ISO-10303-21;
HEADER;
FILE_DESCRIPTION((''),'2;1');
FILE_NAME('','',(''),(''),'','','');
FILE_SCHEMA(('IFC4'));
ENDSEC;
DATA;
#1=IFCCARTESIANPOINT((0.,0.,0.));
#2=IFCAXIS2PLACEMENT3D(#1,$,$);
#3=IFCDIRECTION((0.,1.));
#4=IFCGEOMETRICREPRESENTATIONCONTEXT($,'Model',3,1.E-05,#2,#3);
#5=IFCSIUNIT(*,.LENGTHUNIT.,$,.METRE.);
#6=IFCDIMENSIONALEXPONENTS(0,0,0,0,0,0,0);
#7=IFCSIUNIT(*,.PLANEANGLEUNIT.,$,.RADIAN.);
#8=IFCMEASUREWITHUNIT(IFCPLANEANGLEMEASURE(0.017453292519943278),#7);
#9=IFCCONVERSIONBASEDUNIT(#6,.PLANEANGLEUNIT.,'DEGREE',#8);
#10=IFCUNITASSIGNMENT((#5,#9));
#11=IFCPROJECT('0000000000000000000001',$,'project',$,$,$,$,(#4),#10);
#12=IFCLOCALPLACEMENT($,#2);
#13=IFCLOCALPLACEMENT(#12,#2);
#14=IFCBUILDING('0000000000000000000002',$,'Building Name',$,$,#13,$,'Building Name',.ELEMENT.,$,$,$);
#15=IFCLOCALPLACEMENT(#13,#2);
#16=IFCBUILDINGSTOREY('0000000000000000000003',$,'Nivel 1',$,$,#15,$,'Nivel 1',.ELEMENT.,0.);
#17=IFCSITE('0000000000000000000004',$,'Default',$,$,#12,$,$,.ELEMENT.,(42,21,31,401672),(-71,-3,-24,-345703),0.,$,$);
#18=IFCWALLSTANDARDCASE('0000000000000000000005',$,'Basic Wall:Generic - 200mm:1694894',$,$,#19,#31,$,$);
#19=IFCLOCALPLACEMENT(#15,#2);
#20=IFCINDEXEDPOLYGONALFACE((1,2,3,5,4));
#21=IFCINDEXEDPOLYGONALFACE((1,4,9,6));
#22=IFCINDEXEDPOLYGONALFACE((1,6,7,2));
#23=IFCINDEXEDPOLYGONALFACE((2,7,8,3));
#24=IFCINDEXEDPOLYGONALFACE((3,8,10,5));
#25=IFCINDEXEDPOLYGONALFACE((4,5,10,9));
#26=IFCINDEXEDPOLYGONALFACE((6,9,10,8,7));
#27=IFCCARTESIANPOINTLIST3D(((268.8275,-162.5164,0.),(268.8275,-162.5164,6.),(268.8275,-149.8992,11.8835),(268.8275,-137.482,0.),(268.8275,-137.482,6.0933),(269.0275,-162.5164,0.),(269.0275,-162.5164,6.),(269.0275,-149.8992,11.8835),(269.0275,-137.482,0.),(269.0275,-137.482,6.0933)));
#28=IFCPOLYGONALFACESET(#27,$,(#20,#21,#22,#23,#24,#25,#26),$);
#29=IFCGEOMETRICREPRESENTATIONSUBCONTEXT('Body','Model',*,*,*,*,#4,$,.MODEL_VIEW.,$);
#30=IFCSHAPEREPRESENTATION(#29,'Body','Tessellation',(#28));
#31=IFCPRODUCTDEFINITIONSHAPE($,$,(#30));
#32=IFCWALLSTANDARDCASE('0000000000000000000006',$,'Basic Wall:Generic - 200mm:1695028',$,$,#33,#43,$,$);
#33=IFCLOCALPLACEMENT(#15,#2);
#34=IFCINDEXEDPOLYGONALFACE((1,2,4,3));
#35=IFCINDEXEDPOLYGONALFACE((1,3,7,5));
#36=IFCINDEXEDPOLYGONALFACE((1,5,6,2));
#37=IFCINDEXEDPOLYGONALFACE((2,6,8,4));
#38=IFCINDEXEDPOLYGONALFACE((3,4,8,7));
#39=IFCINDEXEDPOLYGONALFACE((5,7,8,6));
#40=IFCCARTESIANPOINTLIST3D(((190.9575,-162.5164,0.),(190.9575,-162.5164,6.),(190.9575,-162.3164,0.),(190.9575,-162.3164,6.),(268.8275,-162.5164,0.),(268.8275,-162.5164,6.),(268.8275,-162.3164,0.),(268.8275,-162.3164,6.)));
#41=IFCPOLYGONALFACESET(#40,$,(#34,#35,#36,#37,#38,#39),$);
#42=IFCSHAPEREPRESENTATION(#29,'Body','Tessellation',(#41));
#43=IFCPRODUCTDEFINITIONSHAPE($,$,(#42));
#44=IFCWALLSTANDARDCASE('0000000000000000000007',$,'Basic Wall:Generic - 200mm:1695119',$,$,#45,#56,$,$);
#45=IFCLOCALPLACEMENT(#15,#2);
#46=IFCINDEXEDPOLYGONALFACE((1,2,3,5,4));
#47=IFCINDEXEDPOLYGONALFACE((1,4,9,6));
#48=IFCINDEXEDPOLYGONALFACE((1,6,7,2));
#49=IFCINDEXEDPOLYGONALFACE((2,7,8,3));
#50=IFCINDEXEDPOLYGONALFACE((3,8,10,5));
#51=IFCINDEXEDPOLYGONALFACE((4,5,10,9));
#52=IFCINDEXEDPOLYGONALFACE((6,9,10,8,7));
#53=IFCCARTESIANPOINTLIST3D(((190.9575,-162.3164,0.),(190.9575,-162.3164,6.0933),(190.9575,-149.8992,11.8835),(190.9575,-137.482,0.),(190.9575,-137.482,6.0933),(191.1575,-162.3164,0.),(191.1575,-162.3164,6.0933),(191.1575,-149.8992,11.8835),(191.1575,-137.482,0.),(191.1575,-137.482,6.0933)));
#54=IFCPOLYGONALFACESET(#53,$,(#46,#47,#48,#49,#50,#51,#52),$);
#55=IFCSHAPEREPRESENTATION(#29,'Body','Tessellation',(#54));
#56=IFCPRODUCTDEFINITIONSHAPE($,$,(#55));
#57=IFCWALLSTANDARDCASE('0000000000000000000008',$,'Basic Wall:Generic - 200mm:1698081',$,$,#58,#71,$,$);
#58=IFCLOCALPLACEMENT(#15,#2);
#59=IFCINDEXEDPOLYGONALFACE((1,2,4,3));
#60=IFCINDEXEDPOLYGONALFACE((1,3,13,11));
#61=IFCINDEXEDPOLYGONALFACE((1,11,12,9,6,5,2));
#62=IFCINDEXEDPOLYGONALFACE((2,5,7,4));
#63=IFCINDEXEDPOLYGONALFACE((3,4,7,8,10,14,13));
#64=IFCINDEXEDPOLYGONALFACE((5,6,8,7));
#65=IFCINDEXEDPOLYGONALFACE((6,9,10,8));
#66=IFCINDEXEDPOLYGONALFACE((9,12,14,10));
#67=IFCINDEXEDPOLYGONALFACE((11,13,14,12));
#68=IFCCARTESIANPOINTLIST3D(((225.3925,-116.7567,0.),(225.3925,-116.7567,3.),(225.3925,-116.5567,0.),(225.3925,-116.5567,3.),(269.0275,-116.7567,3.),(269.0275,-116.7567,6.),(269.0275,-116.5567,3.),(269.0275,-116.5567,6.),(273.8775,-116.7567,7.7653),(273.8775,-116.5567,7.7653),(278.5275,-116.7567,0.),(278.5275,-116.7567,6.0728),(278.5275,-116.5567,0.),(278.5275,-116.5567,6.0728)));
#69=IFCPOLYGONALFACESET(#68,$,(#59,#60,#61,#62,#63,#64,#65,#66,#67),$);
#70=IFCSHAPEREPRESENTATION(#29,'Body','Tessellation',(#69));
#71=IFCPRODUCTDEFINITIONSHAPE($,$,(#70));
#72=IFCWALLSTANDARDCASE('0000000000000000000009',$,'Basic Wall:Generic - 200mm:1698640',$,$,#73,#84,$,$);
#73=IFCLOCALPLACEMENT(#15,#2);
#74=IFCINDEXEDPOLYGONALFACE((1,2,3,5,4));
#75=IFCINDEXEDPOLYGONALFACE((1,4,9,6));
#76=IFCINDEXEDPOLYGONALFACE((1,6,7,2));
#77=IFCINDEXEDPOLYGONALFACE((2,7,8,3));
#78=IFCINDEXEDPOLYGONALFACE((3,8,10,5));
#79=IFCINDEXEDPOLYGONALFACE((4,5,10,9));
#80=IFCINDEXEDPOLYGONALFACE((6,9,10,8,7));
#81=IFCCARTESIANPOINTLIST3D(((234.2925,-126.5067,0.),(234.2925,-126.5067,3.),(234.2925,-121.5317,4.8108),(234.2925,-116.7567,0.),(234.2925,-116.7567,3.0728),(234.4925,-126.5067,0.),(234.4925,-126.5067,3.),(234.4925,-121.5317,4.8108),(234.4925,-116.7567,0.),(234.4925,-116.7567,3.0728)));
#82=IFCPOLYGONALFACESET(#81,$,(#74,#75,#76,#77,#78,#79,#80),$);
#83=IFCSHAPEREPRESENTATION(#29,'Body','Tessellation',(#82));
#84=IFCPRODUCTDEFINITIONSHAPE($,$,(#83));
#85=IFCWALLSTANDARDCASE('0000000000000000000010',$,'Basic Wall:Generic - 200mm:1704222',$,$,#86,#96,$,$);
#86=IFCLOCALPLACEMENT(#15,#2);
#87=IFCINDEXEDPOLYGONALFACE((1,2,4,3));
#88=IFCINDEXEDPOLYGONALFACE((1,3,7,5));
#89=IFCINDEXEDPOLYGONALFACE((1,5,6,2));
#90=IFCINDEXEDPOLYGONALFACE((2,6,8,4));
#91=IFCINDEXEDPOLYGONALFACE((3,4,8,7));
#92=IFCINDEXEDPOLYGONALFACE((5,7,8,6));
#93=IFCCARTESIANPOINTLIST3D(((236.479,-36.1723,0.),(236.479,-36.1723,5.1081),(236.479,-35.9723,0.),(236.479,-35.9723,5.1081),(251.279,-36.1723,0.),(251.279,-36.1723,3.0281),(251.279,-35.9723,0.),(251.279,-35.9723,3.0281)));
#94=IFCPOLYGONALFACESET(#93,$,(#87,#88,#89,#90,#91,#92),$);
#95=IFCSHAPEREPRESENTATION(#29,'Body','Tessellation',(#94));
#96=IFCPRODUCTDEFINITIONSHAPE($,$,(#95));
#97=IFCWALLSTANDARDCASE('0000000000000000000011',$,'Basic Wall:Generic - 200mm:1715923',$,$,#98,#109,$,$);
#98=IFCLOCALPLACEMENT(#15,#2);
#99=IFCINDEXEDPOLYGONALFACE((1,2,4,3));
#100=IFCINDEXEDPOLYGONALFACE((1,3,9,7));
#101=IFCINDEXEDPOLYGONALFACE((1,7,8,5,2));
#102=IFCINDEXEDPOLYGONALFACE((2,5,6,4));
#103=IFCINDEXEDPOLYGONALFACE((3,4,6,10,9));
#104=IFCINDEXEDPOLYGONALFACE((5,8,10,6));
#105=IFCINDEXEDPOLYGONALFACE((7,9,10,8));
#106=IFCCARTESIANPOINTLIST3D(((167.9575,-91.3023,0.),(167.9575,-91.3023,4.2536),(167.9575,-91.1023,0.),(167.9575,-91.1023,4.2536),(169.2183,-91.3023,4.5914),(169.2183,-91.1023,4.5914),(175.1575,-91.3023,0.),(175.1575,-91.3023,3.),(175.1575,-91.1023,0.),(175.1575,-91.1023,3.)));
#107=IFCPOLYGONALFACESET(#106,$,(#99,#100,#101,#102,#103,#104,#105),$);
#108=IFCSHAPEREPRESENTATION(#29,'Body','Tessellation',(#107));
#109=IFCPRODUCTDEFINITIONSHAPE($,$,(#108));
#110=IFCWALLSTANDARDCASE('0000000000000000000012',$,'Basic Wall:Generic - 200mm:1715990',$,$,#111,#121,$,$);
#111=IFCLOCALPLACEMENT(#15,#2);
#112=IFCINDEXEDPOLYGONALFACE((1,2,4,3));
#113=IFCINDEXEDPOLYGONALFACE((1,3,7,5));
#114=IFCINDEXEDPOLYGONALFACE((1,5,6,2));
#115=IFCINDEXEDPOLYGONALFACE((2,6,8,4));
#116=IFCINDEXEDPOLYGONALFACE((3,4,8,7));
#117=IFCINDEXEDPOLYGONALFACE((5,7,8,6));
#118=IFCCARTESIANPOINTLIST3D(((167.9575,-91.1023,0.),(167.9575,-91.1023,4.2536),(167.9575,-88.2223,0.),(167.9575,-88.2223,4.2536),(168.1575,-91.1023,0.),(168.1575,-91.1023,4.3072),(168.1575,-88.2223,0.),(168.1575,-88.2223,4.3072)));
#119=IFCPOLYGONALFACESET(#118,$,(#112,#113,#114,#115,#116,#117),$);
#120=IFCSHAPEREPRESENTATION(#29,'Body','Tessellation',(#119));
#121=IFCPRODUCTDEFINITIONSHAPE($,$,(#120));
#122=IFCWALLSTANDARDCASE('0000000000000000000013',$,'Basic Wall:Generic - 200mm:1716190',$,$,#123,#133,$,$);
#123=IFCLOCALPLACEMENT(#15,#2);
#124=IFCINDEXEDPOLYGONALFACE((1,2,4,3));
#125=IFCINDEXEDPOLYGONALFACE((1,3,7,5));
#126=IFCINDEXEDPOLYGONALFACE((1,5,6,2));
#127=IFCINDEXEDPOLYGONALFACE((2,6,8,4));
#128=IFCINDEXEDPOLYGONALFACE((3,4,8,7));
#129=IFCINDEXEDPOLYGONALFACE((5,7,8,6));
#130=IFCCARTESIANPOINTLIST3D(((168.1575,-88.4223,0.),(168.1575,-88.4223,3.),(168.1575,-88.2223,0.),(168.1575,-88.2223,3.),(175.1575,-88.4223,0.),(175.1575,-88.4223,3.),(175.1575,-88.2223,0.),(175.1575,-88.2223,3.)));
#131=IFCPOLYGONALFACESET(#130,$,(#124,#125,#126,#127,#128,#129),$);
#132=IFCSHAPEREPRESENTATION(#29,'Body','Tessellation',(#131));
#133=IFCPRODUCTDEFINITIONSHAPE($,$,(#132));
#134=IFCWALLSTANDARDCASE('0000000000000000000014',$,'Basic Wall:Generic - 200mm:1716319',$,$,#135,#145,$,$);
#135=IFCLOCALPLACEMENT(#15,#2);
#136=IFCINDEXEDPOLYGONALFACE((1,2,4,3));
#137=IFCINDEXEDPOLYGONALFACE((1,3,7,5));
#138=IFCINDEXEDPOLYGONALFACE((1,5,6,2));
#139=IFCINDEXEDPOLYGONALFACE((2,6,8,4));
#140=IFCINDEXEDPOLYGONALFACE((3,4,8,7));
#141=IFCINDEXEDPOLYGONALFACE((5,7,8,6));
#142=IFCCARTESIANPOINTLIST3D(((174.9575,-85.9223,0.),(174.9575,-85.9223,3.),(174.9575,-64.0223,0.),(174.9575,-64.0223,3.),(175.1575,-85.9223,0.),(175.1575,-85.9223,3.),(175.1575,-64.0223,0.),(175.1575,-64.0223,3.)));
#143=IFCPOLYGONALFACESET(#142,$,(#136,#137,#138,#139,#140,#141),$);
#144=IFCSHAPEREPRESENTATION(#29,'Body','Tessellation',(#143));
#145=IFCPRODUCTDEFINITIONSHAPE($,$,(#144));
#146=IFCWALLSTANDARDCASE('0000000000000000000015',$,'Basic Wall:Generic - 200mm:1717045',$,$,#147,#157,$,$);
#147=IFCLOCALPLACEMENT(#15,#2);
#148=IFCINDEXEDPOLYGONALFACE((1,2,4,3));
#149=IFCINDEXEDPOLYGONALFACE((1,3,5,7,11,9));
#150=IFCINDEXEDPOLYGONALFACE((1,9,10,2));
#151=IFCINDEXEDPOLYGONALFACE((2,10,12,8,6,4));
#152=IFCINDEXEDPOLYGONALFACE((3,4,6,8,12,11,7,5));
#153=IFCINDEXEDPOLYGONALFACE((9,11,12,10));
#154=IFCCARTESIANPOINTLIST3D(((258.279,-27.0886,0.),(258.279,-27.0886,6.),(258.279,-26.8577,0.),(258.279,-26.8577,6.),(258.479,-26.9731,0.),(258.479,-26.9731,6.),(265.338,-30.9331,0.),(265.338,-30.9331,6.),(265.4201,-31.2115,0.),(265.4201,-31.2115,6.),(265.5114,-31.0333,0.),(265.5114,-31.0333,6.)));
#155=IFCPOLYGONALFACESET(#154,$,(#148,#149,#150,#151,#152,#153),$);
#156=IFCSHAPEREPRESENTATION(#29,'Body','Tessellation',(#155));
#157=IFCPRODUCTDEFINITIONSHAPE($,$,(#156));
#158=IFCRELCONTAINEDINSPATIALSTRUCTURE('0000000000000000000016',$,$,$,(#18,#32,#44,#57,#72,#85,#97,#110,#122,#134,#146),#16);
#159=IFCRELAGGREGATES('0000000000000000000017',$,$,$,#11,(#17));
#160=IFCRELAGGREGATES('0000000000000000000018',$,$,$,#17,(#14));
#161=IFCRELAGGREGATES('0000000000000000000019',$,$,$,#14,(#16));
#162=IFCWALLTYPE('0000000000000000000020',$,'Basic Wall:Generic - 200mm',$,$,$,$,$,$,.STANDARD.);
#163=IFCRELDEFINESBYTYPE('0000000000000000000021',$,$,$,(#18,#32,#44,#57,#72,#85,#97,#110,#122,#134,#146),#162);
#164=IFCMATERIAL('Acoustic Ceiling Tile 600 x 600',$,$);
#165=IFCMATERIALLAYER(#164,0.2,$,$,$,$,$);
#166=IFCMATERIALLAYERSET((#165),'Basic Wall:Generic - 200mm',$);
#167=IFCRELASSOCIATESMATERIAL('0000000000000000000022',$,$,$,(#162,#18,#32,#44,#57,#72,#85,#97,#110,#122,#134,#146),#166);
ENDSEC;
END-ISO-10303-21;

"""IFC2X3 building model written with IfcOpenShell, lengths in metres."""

from ifc_helpers import new_model, entity, si_unit, converted_unit, direction, frame, frame_2d, origin, place, context, subcontext, project, spatial, polyline, rectangle, outline, extrude, clip, bounded_halfspace, material, layer, layer_set, layer_usage, type_object, element, save


model = new_model("IFC2X3")

# Units and contexts
model_context = context("Model", 3, precision=1e-05, world=origin(), true_north=direction((0.0, 1.0)))
body_context = subcontext(model_context, "Body", "Model", "MODEL_VIEW")
ifc_project = project(units=[si_unit("LENGTHUNIT", "METRE"), converted_unit("PLANEANGLEUNIT", "DEGREE", entity("IfcPlaneAngleMeasure", 0.017453292519943278), si_unit("PLANEANGLEUNIT", "RADIAN"), dimensions=[0, 0, 0, 0, 0, 0, 0])], contexts=[model_context])

# Site, building, storey
site_placement = place(None, origin())
site = spatial("IfcSite", under=ifc_project, at=site_placement, Name="Default", CompositionType="ELEMENT", RefLatitude=(42, 21, 31, 401672), RefLongitude=(-71, -3, -24, -345703), RefElevation=0.0)
building_placement = place(site_placement, origin())
building = spatial("IfcBuilding", under=site, at=building_placement, Name="Building Name", LongName="Building Name", CompositionType="ELEMENT")
storey_placement = place(building_placement, origin())
storey = spatial("IfcBuildingStorey", under=building, at=storey_placement, Name="Nivel 1", LongName="Nivel 1", CompositionType="ELEMENT", Elevation=0.0)

# Walls
ifc_material_1 = material(Name="Acoustic Ceiling Tile 600 x 600")
ifc_layer = layer(ifc_material_1, 0.2)
ifc_layer_set = layer_set([ifc_layer], Name="Basic Wall:Generic - 200mm")
wall_type_1 = type_object("IfcWallType", Name="Basic Wall:Generic - 200mm", PredefinedType="STANDARD", material=ifc_layer_set)
ifc_layer_usage_1 = layer_usage(ifc_layer_set, "AXIS2", "NEGATIVE", 0.1)
wall_1_placement = place(storey_placement, frame((268.9275, -137.482, 0.0), z_axis=(0.0, 0.0, 1.0), x_axis=(0.0, -1.0, 0.0)))
element("IfcWallStandardCase", 1, at=wall_1_placement, inside=storey, type_object=wall_type_1, material=ifc_layer_usage_1, Name="Basic Wall:Generic - 200mm:1694894", context=body_context, shape_type="Clipping", body=[
    clip(clip(extrude(rectangle(XDim=25.0344, YDim=0.2, at=frame_2d((12.5172, 0.0), x_axis=(-1.0, 0.0))), origin(), (0.0, 0.0, 1.0), 11.8835), bounded_halfspace(frame((0.0, -0.1, 6.0933), z_axis=(-0.422618, 0.0, 0.906308), x_axis=(0.0, -1.0, 0.0)), False, frame((0.0, -0.1, 6.0933)), polyline([(0.0, 0.0), (12.4172, 0.0), (12.4172, 0.2), (0.0, 0.2), (0.0, 0.0)]))), bounded_halfspace(frame((12.4172, -0.1, 11.8835), z_axis=(0.422618, 0.0, 0.906308), x_axis=(0.0, 1.0, 0.0)), False, frame((12.4172, -0.1, 11.8835)), polyline([(0.0, 0.0), (12.6172, 0.0), (12.6172, 0.2), (0.0, 0.2), (0.0, 0.0)]))),
])
ifc_layer_usage_2 = layer_usage(ifc_layer_set, "AXIS2", "NEGATIVE", 0.1)
wall_2_placement = place(storey_placement, frame((268.8275, -162.4164, 0.0), z_axis=(0.0, 0.0, 1.0), x_axis=(-1.0, 0.0, 0.0)))
element("IfcWallStandardCase", 2, at=wall_2_placement, inside=storey, type_object=wall_type_1, material=ifc_layer_usage_2, Name="Basic Wall:Generic - 200mm:1695028", context=body_context, shape_type="SweptSolid", body=[
    extrude(rectangle(XDim=77.87, YDim=0.2, at=frame_2d((38.935, 0.0), x_axis=(-1.0, 0.0))), origin(), (0.0, 0.0, 1.0), 6.0),
])
ifc_layer_usage_3 = layer_usage(ifc_layer_set, "AXIS2", "NEGATIVE", 0.1)
wall_3_placement = place(storey_placement, frame((191.0575, -162.3164, 0.0), z_axis=(0.0, 0.0, 1.0), x_axis=(0.0, 1.0, 0.0)))
element("IfcWallStandardCase", 3, at=wall_3_placement, inside=storey, type_object=wall_type_1, material=ifc_layer_usage_3, Name="Basic Wall:Generic - 200mm:1695119", context=body_context, shape_type="Clipping", body=[
    clip(clip(extrude(rectangle(XDim=24.8344, YDim=0.2, at=frame_2d((12.4172, 0.0), x_axis=(-1.0, 0.0))), origin(), (0.0, 0.0, 1.0), 11.8835), bounded_halfspace(frame((12.4172, -0.1, 11.8835), z_axis=(0.422618, 0.0, 0.906308), x_axis=(0.0, 1.0, 0.0)), False, frame((12.4172, -0.1, 11.8835)), polyline([(0.0, 0.0), (12.4172, 0.0), (12.4172, 0.2), (0.0, 0.2), (0.0, 0.0)]))), bounded_halfspace(frame((0.0, -0.1, 6.0933), z_axis=(-0.422618, 0.0, 0.906308), x_axis=(0.0, -1.0, 0.0)), False, frame((0.0, -0.1, 6.0933)), polyline([(0.0, 0.0), (12.4172, 0.0), (12.4172, 0.2), (0.0, 0.2), (0.0, 0.0)]))),
])
ifc_layer_usage_4 = layer_usage(ifc_layer_set, "AXIS2", "NEGATIVE", 0.1)
wall_4_placement = place(storey_placement, frame((225.3925, -116.6567, 0.0)))
element("IfcWallStandardCase", 4, at=wall_4_placement, inside=storey, type_object=wall_type_1, material=ifc_layer_usage_4, Name="Basic Wall:Generic - 200mm:1698081", context=body_context, shape_type="Clipping", body=[
    clip(clip(clip(extrude(rectangle(XDim=53.135, YDim=0.2, at=frame_2d((26.5675, 0.0), x_axis=(-1.0, 0.0))), origin(), (0.0, 0.0, 1.0), 7.7653), bounded_halfspace(frame((48.485, -0.1, 7.7653), z_axis=(0.34202, 0.0, 0.939693), x_axis=(0.0, 1.0, 0.0)), False, frame((48.485, -0.1, 7.7653)), polyline([(0.0, 0.0), (4.65, 0.0), (4.65, 0.2), (0.0, 0.2), (0.0, 0.0)]))), bounded_halfspace(frame((43.635, -0.1, 6.0), z_axis=(-0.34202, 0.0, 0.939693), x_axis=(0.0, -1.0, 0.0)), False, frame((43.635, -0.1, 6.0)), polyline([(0.0, 0.0), (4.85, 0.0), (4.85, 0.2), (0.0, 0.2), (0.0, 0.0)]))), bounded_halfspace(frame((0.0, -0.1, 3.0), z_axis=(0.0, 0.0, 1.0), x_axis=(0.0, 1.0, 0.0)), False, frame((0.0, -0.1, 3.0)), polyline([(0.0, 0.0), (43.635, 0.0), (43.635, 0.2), (0.0, 0.2), (0.0, 0.0)]))),
])
ifc_layer_usage_5 = layer_usage(ifc_layer_set, "AXIS2", "NEGATIVE", 0.1)
wall_5_placement = place(storey_placement, frame((234.3925, -116.7567, 0.0), z_axis=(0.0, 0.0, 1.0), x_axis=(0.0, -1.0, 0.0)))
element("IfcWallStandardCase", 5, at=wall_5_placement, inside=storey, type_object=wall_type_1, material=ifc_layer_usage_5, Name="Basic Wall:Generic - 200mm:1698640", context=body_context, shape_type="Clipping", body=[
    clip(clip(extrude(rectangle(XDim=9.75, YDim=0.2, at=frame_2d((4.875, 0.0), x_axis=(-1.0, 0.0))), origin(), (0.0, 0.0, 1.0), 4.8108), bounded_halfspace(frame((0.0, -0.1, 3.0728), z_axis=(-0.34202, 0.0, 0.939693), x_axis=(0.0, -1.0, 0.0)), False, frame((0.0, -0.1, 3.0728)), polyline([(0.0, 0.0), (4.775, 0.0), (4.775, 0.2), (0.0, 0.2), (0.0, 0.0)]))), bounded_halfspace(frame((4.775, -0.1, 4.8108), z_axis=(0.34202, 0.0, 0.939693), x_axis=(0.0, 1.0, 0.0)), False, frame((4.775, -0.1, 4.8108)), polyline([(0.0, 0.0), (4.975, 0.0), (4.975, 0.2), (0.0, 0.2), (0.0, 0.0)]))),
])
ifc_layer_usage_6 = layer_usage(ifc_layer_set, "AXIS2", "NEGATIVE", 0.1)
wall_6_placement = place(storey_placement, frame((251.279, -36.0723, 0.0), z_axis=(0.0, 0.0, 1.0), x_axis=(-1.0, 0.0, 0.0)))
element("IfcWallStandardCase", 6, at=wall_6_placement, inside=storey, type_object=wall_type_1, material=ifc_layer_usage_6, Name="Basic Wall:Generic - 200mm:1704222", context=body_context, shape_type="Clipping", body=[
    clip(extrude(rectangle(XDim=14.8, YDim=0.2, at=frame_2d((7.4, 0.0), x_axis=(-1.0, 0.0))), origin(), (0.0, 0.0, 1.0), 5.1081), bounded_halfspace(frame((0.0, -0.1, 3.0281), z_axis=(-0.139173, 0.0, 0.990268), x_axis=(0.0, -1.0, 0.0)), False, frame((0.0, -0.1, 3.0281)), polyline([(0.0, 0.0), (14.8, 0.0), (14.8, 0.2), (0.0, 0.2), (0.0, 0.0)]))),
])
ifc_layer_usage_7 = layer_usage(ifc_layer_set, "AXIS2", "NEGATIVE", 0.1)
wall_7_placement = place(storey_placement, frame((175.1575, -91.2023, 0.0), z_axis=(0.0, 0.0, 1.0), x_axis=(-1.0, 0.0, 0.0)))
element("IfcWallStandardCase", 7, at=wall_7_placement, inside=storey, type_object=wall_type_1, material=ifc_layer_usage_7, Name="Basic Wall:Generic - 200mm:1715923", context=body_context, shape_type="Clipping", body=[
    clip(clip(extrude(rectangle(XDim=7.2, YDim=0.2, at=frame_2d((3.6, 0.0), x_axis=(-1.0, 0.0))), origin(), (0.0, 0.0, 1.0), 4.5914), bounded_halfspace(frame((5.9392, -0.1, 4.5914), z_axis=(0.258819, 0.0, 0.965926), x_axis=(0.0, 1.0, 0.0)), False, frame((5.9392, -0.1, 4.5914)), polyline([(0.0, 0.0), (1.0608, 0.0), (1.2608, 0.0), (1.2608, 0.2), (0.0, 0.2), (0.0, 0.0)]))), bounded_halfspace(frame((0.0, -0.1, 3.0), z_axis=(-0.258819, 0.0, 0.965926), x_axis=(0.0, -1.0, 0.0)), False, frame((0.0, -0.1, 3.0)), polyline([(0.0, 0.0), (5.9392, 0.0), (5.9392, 0.2), (0.0, 0.2), (0.0, 0.0)]))),
])
ifc_layer_usage_8 = layer_usage(ifc_layer_set, "AXIS2", "NEGATIVE", 0.1)
wall_8_placement = place(storey_placement, frame((168.0575, -91.1023, 0.0), z_axis=(0.0, 0.0, 1.0), x_axis=(0.0, 1.0, 0.0)))
element("IfcWallStandardCase", 8, at=wall_8_placement, inside=storey, type_object=wall_type_1, material=ifc_layer_usage_8, Name="Basic Wall:Generic - 200mm:1715990", context=body_context, shape_type="Clipping", body=[
    clip(extrude(rectangle(XDim=2.88, YDim=0.2, at=frame_2d((1.44, 0.0), x_axis=(-1.0, 0.0))), origin(), (0.0, 0.0, 1.0), 4.3072), bounded_halfspace(frame((0.0, -0.1, 4.3072), z_axis=(0.0, 0.258819, 0.965926), x_axis=(-1.0, 0.0, 0.0)), False, frame((0.0, -0.1, 4.3072)), polyline([(0.0, 0.0), (2.88, 0.0), (2.88, 0.2), (0.0, 0.2), (0.0, 0.0)]))),
])
ifc_layer_usage_9 = layer_usage(ifc_layer_set, "AXIS2", "NEGATIVE", 0.1)
wall_9_placement = place(storey_placement, frame((168.1575, -88.3223, 0.0)))
element("IfcWallStandardCase", 9, at=wall_9_placement, inside=storey, type_object=wall_type_1, material=ifc_layer_usage_9, Name="Basic Wall:Generic - 200mm:1716190", context=body_context, shape_type="SweptSolid", body=[
    extrude(rectangle(XDim=7.0, YDim=0.2, at=frame_2d((3.5, 0.0), x_axis=(-1.0, 0.0))), origin(), (0.0, 0.0, 1.0), 3.0),
])
ifc_layer_usage_10 = layer_usage(ifc_layer_set, "AXIS2", "NEGATIVE", 0.1)
wall_10_placement = place(storey_placement, frame((175.0575, -85.9223, 0.0), z_axis=(0.0, 0.0, 1.0), x_axis=(0.0, 1.0, 0.0)))
element("IfcWallStandardCase", 10, at=wall_10_placement, inside=storey, type_object=wall_type_1, material=ifc_layer_usage_10, Name="Basic Wall:Generic - 200mm:1716319", context=body_context, shape_type="SweptSolid", body=[
    extrude(rectangle(XDim=21.9, YDim=0.2, at=frame_2d((10.95, 0.0), x_axis=(-1.0, 0.0))), origin(), (0.0, 0.0, 1.0), 3.0),
])
ifc_layer_usage_11 = layer_usage(ifc_layer_set, "AXIS2", "NEGATIVE", 0.1)
wall_11_placement = place(storey_placement, frame((265.4701, -31.1249, 0.0), z_axis=(0.0, 0.0, 1.0), x_axis=(-0.866025, 0.5, 0.0)))
element("IfcWallStandardCase", 11, at=wall_11_placement, inside=storey, type_object=wall_type_1, material=ifc_layer_usage_11, Name="Basic Wall:Generic - 200mm:1717045", context=body_context, shape_type="SweptSolid", body=[
    extrude(outline(polyline([(8.3613, -0.1), (8.2458, 0.1), (0.0, 0.1), (0.0101, -0.1), (0.2104, -0.1), (8.1304, -0.1), (8.3613, -0.1)])), origin(), (0.0, 0.0, 1.0), 6.0),
])

save(model, "model.ifc")
